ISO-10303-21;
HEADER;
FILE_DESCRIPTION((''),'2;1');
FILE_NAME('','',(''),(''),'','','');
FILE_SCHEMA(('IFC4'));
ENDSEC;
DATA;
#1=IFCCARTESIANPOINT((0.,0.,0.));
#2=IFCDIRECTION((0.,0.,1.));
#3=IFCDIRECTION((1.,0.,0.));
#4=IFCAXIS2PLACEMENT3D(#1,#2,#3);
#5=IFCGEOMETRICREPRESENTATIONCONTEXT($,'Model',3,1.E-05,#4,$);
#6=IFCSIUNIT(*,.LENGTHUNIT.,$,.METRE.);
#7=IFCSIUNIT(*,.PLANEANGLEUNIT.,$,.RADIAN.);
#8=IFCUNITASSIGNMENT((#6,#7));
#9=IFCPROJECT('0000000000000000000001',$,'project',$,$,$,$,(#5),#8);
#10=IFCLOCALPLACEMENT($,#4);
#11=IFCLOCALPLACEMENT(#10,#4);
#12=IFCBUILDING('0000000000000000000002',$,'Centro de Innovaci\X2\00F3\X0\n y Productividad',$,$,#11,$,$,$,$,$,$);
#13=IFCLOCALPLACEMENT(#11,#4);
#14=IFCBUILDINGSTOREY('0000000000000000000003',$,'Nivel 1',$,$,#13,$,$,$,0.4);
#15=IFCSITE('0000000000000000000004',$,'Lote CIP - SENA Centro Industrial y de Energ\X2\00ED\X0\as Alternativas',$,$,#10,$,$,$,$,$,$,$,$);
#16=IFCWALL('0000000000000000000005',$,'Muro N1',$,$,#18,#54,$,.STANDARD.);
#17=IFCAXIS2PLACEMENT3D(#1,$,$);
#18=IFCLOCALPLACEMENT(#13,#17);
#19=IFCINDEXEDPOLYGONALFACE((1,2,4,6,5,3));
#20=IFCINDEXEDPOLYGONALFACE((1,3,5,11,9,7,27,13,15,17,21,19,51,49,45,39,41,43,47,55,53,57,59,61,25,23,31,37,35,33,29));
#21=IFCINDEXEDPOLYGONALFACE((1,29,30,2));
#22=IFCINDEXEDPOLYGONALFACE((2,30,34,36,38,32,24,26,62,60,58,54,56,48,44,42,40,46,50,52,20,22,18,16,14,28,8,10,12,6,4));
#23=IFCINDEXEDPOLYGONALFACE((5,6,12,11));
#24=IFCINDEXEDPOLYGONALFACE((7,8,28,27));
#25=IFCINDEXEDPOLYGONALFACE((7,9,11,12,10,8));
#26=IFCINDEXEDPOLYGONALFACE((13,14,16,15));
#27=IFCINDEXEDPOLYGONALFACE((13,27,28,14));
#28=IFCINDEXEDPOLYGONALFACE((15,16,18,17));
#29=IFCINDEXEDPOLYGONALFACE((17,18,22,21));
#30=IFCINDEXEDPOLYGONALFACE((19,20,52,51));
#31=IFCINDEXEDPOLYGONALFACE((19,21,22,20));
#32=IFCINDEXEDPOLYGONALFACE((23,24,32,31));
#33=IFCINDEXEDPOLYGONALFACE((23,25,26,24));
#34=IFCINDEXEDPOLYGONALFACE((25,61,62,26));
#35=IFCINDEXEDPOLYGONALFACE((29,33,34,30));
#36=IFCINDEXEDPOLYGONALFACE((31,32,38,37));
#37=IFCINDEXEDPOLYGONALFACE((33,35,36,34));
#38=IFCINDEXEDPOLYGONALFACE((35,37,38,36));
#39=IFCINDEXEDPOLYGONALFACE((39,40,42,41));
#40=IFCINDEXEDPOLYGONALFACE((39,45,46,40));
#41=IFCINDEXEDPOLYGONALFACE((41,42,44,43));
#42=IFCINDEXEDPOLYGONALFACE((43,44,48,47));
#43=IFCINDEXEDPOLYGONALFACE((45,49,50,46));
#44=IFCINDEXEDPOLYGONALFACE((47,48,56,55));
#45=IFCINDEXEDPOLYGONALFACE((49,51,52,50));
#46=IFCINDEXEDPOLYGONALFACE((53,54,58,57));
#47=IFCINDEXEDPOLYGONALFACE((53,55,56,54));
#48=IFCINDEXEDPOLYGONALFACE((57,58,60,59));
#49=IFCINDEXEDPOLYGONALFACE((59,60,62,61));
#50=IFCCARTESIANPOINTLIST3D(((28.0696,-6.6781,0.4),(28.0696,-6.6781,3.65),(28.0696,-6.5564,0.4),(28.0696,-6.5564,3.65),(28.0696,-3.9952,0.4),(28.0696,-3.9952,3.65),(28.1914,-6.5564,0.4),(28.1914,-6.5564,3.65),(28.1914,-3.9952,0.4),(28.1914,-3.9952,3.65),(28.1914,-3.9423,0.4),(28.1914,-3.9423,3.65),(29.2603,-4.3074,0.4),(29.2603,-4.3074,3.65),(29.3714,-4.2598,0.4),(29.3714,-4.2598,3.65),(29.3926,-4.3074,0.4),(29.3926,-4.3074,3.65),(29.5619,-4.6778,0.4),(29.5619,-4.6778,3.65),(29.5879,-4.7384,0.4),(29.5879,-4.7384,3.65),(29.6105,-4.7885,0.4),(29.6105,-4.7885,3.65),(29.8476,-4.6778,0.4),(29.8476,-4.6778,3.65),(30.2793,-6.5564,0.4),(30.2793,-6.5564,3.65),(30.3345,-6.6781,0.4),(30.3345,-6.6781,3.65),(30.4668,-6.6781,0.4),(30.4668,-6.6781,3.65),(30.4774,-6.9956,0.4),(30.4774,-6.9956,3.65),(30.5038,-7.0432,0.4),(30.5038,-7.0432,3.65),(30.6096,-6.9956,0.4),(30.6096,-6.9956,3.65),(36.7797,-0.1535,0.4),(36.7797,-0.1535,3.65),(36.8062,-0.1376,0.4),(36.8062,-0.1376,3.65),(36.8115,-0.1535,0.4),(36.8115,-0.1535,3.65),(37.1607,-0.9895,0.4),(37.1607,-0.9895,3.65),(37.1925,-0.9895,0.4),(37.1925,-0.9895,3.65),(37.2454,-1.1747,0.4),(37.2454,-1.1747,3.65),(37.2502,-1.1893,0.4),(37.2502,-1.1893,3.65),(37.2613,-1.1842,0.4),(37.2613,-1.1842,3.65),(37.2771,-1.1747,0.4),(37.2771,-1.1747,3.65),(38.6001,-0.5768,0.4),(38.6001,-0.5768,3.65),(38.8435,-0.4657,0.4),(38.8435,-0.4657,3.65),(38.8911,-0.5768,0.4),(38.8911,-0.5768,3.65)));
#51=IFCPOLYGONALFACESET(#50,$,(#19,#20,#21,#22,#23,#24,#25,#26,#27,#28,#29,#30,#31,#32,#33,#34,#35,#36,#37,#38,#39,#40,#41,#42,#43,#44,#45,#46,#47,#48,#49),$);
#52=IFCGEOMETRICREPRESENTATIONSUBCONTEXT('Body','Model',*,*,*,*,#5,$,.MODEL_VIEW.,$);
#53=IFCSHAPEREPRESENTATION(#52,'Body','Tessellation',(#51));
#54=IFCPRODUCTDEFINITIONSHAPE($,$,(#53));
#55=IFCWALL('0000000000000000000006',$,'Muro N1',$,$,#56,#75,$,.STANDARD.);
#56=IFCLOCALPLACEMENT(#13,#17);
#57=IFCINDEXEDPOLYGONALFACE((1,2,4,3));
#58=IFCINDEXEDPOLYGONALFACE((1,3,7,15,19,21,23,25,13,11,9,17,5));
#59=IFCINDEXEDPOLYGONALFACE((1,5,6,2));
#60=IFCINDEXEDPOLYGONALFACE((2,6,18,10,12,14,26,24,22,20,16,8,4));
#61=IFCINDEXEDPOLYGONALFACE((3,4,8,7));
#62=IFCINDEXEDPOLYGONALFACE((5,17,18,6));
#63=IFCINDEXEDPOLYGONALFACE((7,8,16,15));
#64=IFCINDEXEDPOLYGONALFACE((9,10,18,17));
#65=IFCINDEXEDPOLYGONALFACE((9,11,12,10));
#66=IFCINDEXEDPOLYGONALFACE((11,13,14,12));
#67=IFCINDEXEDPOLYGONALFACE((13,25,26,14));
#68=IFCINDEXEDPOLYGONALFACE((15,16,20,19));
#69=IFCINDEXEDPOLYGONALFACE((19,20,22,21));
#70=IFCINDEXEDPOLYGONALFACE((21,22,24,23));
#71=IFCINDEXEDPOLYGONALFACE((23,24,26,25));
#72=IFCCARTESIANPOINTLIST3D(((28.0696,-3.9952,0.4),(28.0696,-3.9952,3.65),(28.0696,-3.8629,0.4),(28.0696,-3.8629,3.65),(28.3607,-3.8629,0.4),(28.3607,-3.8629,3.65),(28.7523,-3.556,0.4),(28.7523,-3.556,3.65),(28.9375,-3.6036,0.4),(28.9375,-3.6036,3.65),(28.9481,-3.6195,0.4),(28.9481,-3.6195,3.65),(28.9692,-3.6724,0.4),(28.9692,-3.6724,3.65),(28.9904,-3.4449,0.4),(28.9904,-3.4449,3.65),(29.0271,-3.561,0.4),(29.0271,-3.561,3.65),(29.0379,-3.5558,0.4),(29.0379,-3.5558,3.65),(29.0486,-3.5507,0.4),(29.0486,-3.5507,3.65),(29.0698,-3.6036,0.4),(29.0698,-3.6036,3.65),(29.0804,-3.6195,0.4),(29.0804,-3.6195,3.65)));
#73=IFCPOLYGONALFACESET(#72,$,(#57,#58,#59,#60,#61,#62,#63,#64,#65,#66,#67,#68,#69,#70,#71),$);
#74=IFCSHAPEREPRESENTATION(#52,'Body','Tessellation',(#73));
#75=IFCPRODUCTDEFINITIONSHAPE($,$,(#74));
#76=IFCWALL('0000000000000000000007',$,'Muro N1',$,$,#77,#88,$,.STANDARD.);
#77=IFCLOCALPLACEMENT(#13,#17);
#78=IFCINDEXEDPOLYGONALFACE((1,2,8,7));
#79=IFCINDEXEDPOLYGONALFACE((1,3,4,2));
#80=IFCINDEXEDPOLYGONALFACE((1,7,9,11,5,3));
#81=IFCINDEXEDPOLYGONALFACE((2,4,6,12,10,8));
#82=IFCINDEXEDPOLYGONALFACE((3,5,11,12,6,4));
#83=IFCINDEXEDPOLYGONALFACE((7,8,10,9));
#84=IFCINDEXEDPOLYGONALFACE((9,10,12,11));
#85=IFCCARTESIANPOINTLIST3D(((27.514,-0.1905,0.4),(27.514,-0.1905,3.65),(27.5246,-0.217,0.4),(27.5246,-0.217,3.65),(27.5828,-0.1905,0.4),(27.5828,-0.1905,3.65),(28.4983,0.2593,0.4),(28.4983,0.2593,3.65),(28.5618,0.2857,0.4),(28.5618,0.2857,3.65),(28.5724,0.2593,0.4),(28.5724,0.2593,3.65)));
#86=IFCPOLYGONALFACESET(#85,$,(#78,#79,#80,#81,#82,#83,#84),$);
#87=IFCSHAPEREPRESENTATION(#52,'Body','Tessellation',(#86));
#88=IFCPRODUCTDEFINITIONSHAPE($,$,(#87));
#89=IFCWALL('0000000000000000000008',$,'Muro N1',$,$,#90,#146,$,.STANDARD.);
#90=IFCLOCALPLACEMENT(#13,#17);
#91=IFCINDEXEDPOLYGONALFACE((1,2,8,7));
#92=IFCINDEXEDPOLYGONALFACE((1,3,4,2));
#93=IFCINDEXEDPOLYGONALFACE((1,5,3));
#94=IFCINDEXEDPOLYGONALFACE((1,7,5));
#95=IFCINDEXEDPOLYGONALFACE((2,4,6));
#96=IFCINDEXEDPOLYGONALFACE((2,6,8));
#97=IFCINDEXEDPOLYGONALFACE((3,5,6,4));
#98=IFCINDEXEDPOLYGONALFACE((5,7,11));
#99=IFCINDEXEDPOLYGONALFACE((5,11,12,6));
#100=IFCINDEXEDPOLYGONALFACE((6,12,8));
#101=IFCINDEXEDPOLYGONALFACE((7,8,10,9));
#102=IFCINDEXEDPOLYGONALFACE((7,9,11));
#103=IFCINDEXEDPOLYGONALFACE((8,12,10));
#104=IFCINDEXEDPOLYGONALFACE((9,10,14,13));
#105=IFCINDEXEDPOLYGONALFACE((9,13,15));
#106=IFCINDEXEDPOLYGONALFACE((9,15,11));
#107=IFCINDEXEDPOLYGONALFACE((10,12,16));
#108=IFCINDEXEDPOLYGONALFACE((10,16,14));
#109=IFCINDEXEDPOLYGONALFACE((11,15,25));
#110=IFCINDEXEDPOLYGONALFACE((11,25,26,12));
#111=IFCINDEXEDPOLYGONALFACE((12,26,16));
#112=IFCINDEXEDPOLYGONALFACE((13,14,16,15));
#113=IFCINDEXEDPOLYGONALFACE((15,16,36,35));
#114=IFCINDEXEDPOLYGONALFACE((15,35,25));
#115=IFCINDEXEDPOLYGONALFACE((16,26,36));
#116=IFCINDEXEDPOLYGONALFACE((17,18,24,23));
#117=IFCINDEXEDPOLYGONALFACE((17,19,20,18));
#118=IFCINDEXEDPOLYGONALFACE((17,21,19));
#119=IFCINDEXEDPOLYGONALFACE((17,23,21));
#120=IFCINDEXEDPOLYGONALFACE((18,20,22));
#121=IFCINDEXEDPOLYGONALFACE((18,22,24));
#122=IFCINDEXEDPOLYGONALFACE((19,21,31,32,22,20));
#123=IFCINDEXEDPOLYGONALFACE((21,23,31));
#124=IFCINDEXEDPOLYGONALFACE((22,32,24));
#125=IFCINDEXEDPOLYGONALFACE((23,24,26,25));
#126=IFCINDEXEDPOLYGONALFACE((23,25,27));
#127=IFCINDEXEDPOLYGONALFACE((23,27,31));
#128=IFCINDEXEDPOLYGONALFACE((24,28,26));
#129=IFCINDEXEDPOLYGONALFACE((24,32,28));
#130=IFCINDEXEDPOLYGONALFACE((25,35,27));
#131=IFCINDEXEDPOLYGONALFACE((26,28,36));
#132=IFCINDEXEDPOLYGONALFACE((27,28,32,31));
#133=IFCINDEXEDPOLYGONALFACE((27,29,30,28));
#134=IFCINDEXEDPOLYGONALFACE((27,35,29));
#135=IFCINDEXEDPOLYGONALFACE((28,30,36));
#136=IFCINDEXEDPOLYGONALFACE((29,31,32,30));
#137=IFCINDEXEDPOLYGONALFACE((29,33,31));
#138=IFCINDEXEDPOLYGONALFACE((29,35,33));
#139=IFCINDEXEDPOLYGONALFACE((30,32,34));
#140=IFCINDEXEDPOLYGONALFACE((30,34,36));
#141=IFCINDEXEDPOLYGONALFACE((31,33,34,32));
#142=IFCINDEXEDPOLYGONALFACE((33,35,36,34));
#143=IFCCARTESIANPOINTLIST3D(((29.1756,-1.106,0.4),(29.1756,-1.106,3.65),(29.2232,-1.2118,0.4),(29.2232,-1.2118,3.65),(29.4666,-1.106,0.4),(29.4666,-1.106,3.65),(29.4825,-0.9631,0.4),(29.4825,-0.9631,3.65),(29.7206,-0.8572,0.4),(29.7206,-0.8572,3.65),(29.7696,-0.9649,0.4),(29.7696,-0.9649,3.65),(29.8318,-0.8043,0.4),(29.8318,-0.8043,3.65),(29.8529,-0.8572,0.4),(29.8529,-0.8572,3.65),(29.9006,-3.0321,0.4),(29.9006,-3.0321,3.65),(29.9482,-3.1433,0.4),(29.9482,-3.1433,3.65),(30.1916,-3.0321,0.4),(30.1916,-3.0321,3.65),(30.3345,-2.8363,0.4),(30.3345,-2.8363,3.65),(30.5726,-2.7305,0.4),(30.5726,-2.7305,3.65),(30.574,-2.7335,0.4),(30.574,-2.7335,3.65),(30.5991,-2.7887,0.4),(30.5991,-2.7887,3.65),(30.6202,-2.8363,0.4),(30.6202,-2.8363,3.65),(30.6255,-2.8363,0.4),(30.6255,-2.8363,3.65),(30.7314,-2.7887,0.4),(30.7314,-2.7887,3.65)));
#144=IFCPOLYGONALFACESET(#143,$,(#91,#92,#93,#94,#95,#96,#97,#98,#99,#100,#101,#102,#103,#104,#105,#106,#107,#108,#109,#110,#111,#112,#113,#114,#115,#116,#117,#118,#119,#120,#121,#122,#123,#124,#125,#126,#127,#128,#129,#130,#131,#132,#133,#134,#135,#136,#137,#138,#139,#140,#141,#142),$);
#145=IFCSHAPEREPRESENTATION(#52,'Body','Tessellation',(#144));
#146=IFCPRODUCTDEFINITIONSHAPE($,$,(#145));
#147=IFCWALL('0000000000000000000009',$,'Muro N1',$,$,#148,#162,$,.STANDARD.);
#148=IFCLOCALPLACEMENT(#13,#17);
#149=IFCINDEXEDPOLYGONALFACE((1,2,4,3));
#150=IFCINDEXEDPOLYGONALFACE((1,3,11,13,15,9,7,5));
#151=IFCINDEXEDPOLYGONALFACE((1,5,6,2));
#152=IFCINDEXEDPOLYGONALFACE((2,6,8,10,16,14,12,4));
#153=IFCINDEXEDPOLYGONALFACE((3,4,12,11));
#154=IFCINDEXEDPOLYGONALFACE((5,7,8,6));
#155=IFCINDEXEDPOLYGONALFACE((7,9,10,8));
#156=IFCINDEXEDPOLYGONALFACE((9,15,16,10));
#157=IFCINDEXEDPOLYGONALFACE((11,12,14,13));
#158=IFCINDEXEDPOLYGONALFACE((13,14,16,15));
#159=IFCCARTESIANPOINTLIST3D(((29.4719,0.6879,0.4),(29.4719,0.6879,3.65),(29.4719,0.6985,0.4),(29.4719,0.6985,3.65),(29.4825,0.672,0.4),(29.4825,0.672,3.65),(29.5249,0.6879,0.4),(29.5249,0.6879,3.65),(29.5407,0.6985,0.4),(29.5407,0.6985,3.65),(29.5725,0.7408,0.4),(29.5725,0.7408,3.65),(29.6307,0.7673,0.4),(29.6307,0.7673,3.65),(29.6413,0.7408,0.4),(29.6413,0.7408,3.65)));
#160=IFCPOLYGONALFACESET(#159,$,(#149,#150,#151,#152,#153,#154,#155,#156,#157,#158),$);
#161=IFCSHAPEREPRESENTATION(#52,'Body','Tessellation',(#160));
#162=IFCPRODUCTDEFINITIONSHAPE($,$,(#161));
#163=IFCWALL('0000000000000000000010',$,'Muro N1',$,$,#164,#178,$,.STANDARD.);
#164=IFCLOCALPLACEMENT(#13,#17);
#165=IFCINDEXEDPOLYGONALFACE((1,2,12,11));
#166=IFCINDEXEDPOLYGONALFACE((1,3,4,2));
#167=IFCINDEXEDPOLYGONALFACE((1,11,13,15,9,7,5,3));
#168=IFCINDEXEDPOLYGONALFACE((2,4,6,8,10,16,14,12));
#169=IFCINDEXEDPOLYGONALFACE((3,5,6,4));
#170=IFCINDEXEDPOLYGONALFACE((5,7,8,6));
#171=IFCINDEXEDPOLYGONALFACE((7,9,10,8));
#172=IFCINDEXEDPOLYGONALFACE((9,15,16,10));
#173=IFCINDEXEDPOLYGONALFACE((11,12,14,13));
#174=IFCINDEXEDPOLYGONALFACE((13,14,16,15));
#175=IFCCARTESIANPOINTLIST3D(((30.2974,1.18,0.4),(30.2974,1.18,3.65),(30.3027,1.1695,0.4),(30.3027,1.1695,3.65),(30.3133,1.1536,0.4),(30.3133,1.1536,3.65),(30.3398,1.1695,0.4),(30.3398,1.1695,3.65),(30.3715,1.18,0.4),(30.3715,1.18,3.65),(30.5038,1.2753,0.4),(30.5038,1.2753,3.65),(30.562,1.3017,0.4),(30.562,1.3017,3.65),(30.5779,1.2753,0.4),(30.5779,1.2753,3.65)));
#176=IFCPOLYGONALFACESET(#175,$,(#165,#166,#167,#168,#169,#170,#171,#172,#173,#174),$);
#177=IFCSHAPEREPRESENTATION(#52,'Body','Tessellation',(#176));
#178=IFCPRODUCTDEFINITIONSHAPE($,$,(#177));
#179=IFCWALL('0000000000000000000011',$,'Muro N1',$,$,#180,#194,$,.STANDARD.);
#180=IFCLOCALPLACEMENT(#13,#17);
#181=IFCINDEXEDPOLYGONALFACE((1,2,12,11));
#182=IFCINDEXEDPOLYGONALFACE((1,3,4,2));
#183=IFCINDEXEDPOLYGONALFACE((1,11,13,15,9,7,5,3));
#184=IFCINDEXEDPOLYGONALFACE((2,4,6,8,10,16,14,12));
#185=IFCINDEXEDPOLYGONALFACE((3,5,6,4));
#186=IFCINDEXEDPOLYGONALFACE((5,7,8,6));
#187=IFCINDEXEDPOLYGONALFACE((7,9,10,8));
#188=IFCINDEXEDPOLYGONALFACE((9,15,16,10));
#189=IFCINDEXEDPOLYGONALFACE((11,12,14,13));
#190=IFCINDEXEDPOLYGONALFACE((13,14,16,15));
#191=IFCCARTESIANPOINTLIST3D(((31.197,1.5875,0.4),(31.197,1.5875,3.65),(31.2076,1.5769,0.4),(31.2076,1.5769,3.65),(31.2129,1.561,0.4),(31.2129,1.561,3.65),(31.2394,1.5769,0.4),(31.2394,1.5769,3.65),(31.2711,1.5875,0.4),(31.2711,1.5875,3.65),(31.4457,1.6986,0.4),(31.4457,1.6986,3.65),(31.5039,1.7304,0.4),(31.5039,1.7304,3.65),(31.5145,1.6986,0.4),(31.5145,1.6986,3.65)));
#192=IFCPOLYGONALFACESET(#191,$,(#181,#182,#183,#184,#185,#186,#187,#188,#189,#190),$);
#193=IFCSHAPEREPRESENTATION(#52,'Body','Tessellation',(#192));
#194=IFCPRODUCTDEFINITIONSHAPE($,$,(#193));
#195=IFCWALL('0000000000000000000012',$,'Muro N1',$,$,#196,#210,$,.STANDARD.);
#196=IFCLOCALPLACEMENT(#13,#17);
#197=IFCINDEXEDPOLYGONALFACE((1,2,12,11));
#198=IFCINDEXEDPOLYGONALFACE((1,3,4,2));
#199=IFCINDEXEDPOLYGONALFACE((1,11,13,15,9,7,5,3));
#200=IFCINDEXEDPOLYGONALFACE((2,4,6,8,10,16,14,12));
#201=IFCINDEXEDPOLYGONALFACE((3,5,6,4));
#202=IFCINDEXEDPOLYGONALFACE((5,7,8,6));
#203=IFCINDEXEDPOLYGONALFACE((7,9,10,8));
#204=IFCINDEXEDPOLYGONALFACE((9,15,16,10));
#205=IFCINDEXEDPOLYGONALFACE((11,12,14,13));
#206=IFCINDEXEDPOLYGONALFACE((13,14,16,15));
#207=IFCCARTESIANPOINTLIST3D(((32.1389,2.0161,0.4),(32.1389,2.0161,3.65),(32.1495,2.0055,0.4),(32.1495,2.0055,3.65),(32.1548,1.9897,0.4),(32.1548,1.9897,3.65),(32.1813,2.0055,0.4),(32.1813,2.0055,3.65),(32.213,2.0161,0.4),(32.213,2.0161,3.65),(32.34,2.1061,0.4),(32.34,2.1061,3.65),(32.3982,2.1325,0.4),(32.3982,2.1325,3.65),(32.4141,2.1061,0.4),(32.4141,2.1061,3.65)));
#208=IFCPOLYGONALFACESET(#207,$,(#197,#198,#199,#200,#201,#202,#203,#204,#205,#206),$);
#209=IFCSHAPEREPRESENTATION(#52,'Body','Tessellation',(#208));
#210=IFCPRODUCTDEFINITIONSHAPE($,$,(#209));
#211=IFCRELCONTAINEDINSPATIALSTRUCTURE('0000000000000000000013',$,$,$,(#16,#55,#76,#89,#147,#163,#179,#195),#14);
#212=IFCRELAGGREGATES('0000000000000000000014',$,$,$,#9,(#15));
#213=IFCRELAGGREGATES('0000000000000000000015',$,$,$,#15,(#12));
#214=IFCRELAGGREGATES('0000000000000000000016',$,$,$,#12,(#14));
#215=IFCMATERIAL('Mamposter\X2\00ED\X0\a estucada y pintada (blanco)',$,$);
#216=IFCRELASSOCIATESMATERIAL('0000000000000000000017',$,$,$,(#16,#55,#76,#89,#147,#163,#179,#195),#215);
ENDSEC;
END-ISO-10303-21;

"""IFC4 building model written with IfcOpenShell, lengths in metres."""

from ifc_helpers import new_model, si_unit, frame, origin_with_axes, place, context, subcontext, project, spatial, polyline, outline, extrude, material, element, save


model = new_model("IFC4")

# Units and contexts
model_context = context("Model", 3, precision=1e-05, world=origin_with_axes())
body_context = subcontext(model_context, "Body", "Model", "MODEL_VIEW")
ifc_project = project(units=[si_unit("LENGTHUNIT", "METRE"), si_unit("PLANEANGLEUNIT", "RADIAN")], contexts=[model_context])

# Site, building, storey
site_placement = place(None, origin_with_axes())
site = spatial("IfcSite", under=ifc_project, at=site_placement, Name="Lote CIP - SENA Centro Industrial y de Energías Alternativas")
building_placement = place(site_placement, origin_with_axes())
building = spatial("IfcBuilding", under=site, at=building_placement, Name="Centro de Innovación y Productividad")
storey_placement = place(building_placement, origin_with_axes())
storey = spatial("IfcBuildingStorey", under=building, at=storey_placement, Name="Nivel 1", Elevation=0.4)

# Walls
ifc_material = material(Name="Mampostería estucada y pintada (blanco)")
wall_1_placement = place(storey_placement, origin_with_axes())
element("IfcWall", 1, at=wall_1_placement, inside=storey, material=ifc_material, Name="Muro N1", PredefinedType="STANDARD", context=body_context, shape_type="SweptSolid", body=[
    extrude(outline(polyline([(28.1914, -3.9952), (28.1914, -6.5564), (30.2793, -6.5564), (29.2603, -4.3074), (29.3714, -4.2598), (29.3926, -4.3074), (29.5879, -4.7384), (29.5619, -4.6778), (37.2502, -1.1893), (37.2454, -1.1747), (37.1607, -0.9895), (36.7797, -0.1535), (36.8062, -0.1376), (36.8115, -0.1535), (37.1925, -0.9895), (37.2771, -1.1747), (37.2613, -1.1842), (38.6001, -0.5768), (38.8435, -0.4657), (38.8911, -0.5768), (29.8476, -4.6778), (29.6105, -4.7885), (30.4668, -6.6781), (30.6096, -6.9956), (30.5038, -7.0432), (30.4774, -6.9956), (30.3345, -6.6781), (28.0696, -6.6781), (28.0696, -6.5564), (28.0696, -3.9952), (28.1914, -3.9423), (28.1914, -3.9952)])), frame((0.0, 0.0, 0.4)), (0.0, 0.0, 1.0), 3.25),
])
wall_2_placement = place(storey_placement, origin_with_axes())
element("IfcWall", 2, at=wall_2_placement, inside=storey, material=ifc_material, Name="Muro N1", PredefinedType="STANDARD", context=body_context, shape_type="SweptSolid", body=[
    extrude(outline(polyline([(28.9481, -3.6195), (28.9375, -3.6036), (29.0271, -3.561), (28.3607, -3.8629), (28.0696, -3.9952), (28.0696, -3.8629), (28.7523, -3.556), (28.9904, -3.4449), (29.0379, -3.5558), (29.0486, -3.5507), (29.0698, -3.6036), (29.0804, -3.6195), (28.9692, -3.6724), (28.9481, -3.6195)])), frame((0.0, 0.0, 0.4)), (0.0, 0.0, 1.0), 3.25),
])
wall_3_placement = place(storey_placement, origin_with_axes())
element("IfcWall", 3, at=wall_3_placement, inside=storey, material=ifc_material, Name="Muro N1", PredefinedType="STANDARD", context=body_context, shape_type="SweptSolid", body=[
    extrude(outline(polyline([(28.4983, 0.2593), (28.5618, 0.2857), (28.5724, 0.2593), (27.5828, -0.1905), (27.5246, -0.217), (27.514, -0.1905), (28.4983, 0.2593)])), frame((0.0, 0.0, 0.4)), (0.0, 0.0, 1.0), 3.25),
])
wall_4_placement = place(storey_placement, origin_with_axes())
element("IfcWall", 4, at=wall_4_placement, inside=storey, material=ifc_material, Name="Muro N1", PredefinedType="STANDARD", context=body_context, shape_type="SweptSolid", body=[
    extrude(outline(polyline([(29.4825, -0.9631), (29.7206, -0.8572), (29.8318, -0.8043), (29.8529, -0.8572), (30.7314, -2.7887), (30.6255, -2.8363), (30.6202, -2.8363), (30.1916, -3.0321), (29.9482, -3.1433), (29.9006, -3.0321), (30.3345, -2.8363), (30.5726, -2.7305), (29.7696, -0.9649), (29.4666, -1.106), (29.2232, -1.2118), (29.1756, -1.106), (29.4825, -0.9631)]), holes=[polyline([(30.6202, -2.8363), (30.5991, -2.7887), (30.574, -2.7335), (30.6202, -2.8363)])]), frame((0.0, 0.0, 0.4)), (0.0, 0.0, 1.0), 3.25),
])
wall_5_placement = place(storey_placement, origin_with_axes())
element("IfcWall", 5, at=wall_5_placement, inside=storey, material=ifc_material, Name="Muro N1", PredefinedType="STANDARD", context=body_context, shape_type="SweptSolid", body=[
    extrude(outline(polyline([(29.6413, 0.7408), (29.5407, 0.6985), (29.5249, 0.6879), (29.4825, 0.672), (29.4719, 0.6879), (29.4719, 0.6985), (29.5725, 0.7408), (29.6307, 0.7673), (29.6413, 0.7408)])), frame((0.0, 0.0, 0.4)), (0.0, 0.0, 1.0), 3.25),
])
wall_6_placement = place(storey_placement, origin_with_axes())
element("IfcWall", 6, at=wall_6_placement, inside=storey, material=ifc_material, Name="Muro N1", PredefinedType="STANDARD", context=body_context, shape_type="SweptSolid", body=[
    extrude(outline(polyline([(30.562, 1.3017), (30.5779, 1.2753), (30.3715, 1.18), (30.3398, 1.1695), (30.3133, 1.1536), (30.3027, 1.1695), (30.2974, 1.18), (30.5038, 1.2753), (30.562, 1.3017)])), frame((0.0, 0.0, 0.4)), (0.0, 0.0, 1.0), 3.25),
])
wall_7_placement = place(storey_placement, origin_with_axes())
element("IfcWall", 7, at=wall_7_placement, inside=storey, material=ifc_material, Name="Muro N1", PredefinedType="STANDARD", context=body_context, shape_type="SweptSolid", body=[
    extrude(outline(polyline([(31.2711, 1.5875), (31.2394, 1.5769), (31.2129, 1.561), (31.2076, 1.5769), (31.197, 1.5875), (31.4457, 1.6986), (31.5039, 1.7304), (31.5145, 1.6986), (31.2711, 1.5875)])), frame((0.0, 0.0, 0.4)), (0.0, 0.0, 1.0), 3.25),
])
wall_8_placement = place(storey_placement, origin_with_axes())
element("IfcWall", 8, at=wall_8_placement, inside=storey, material=ifc_material, Name="Muro N1", PredefinedType="STANDARD", context=body_context, shape_type="SweptSolid", body=[
    extrude(outline(polyline([(32.34, 2.1061), (32.3982, 2.1325), (32.4141, 2.1061), (32.213, 2.0161), (32.1813, 2.0055), (32.1548, 1.9897), (32.1495, 2.0055), (32.1389, 2.0161), (32.34, 2.1061)])), frame((0.0, 0.0, 0.4)), (0.0, 0.0, 1.0), 3.25),
])

save(model, "model.ifc")
